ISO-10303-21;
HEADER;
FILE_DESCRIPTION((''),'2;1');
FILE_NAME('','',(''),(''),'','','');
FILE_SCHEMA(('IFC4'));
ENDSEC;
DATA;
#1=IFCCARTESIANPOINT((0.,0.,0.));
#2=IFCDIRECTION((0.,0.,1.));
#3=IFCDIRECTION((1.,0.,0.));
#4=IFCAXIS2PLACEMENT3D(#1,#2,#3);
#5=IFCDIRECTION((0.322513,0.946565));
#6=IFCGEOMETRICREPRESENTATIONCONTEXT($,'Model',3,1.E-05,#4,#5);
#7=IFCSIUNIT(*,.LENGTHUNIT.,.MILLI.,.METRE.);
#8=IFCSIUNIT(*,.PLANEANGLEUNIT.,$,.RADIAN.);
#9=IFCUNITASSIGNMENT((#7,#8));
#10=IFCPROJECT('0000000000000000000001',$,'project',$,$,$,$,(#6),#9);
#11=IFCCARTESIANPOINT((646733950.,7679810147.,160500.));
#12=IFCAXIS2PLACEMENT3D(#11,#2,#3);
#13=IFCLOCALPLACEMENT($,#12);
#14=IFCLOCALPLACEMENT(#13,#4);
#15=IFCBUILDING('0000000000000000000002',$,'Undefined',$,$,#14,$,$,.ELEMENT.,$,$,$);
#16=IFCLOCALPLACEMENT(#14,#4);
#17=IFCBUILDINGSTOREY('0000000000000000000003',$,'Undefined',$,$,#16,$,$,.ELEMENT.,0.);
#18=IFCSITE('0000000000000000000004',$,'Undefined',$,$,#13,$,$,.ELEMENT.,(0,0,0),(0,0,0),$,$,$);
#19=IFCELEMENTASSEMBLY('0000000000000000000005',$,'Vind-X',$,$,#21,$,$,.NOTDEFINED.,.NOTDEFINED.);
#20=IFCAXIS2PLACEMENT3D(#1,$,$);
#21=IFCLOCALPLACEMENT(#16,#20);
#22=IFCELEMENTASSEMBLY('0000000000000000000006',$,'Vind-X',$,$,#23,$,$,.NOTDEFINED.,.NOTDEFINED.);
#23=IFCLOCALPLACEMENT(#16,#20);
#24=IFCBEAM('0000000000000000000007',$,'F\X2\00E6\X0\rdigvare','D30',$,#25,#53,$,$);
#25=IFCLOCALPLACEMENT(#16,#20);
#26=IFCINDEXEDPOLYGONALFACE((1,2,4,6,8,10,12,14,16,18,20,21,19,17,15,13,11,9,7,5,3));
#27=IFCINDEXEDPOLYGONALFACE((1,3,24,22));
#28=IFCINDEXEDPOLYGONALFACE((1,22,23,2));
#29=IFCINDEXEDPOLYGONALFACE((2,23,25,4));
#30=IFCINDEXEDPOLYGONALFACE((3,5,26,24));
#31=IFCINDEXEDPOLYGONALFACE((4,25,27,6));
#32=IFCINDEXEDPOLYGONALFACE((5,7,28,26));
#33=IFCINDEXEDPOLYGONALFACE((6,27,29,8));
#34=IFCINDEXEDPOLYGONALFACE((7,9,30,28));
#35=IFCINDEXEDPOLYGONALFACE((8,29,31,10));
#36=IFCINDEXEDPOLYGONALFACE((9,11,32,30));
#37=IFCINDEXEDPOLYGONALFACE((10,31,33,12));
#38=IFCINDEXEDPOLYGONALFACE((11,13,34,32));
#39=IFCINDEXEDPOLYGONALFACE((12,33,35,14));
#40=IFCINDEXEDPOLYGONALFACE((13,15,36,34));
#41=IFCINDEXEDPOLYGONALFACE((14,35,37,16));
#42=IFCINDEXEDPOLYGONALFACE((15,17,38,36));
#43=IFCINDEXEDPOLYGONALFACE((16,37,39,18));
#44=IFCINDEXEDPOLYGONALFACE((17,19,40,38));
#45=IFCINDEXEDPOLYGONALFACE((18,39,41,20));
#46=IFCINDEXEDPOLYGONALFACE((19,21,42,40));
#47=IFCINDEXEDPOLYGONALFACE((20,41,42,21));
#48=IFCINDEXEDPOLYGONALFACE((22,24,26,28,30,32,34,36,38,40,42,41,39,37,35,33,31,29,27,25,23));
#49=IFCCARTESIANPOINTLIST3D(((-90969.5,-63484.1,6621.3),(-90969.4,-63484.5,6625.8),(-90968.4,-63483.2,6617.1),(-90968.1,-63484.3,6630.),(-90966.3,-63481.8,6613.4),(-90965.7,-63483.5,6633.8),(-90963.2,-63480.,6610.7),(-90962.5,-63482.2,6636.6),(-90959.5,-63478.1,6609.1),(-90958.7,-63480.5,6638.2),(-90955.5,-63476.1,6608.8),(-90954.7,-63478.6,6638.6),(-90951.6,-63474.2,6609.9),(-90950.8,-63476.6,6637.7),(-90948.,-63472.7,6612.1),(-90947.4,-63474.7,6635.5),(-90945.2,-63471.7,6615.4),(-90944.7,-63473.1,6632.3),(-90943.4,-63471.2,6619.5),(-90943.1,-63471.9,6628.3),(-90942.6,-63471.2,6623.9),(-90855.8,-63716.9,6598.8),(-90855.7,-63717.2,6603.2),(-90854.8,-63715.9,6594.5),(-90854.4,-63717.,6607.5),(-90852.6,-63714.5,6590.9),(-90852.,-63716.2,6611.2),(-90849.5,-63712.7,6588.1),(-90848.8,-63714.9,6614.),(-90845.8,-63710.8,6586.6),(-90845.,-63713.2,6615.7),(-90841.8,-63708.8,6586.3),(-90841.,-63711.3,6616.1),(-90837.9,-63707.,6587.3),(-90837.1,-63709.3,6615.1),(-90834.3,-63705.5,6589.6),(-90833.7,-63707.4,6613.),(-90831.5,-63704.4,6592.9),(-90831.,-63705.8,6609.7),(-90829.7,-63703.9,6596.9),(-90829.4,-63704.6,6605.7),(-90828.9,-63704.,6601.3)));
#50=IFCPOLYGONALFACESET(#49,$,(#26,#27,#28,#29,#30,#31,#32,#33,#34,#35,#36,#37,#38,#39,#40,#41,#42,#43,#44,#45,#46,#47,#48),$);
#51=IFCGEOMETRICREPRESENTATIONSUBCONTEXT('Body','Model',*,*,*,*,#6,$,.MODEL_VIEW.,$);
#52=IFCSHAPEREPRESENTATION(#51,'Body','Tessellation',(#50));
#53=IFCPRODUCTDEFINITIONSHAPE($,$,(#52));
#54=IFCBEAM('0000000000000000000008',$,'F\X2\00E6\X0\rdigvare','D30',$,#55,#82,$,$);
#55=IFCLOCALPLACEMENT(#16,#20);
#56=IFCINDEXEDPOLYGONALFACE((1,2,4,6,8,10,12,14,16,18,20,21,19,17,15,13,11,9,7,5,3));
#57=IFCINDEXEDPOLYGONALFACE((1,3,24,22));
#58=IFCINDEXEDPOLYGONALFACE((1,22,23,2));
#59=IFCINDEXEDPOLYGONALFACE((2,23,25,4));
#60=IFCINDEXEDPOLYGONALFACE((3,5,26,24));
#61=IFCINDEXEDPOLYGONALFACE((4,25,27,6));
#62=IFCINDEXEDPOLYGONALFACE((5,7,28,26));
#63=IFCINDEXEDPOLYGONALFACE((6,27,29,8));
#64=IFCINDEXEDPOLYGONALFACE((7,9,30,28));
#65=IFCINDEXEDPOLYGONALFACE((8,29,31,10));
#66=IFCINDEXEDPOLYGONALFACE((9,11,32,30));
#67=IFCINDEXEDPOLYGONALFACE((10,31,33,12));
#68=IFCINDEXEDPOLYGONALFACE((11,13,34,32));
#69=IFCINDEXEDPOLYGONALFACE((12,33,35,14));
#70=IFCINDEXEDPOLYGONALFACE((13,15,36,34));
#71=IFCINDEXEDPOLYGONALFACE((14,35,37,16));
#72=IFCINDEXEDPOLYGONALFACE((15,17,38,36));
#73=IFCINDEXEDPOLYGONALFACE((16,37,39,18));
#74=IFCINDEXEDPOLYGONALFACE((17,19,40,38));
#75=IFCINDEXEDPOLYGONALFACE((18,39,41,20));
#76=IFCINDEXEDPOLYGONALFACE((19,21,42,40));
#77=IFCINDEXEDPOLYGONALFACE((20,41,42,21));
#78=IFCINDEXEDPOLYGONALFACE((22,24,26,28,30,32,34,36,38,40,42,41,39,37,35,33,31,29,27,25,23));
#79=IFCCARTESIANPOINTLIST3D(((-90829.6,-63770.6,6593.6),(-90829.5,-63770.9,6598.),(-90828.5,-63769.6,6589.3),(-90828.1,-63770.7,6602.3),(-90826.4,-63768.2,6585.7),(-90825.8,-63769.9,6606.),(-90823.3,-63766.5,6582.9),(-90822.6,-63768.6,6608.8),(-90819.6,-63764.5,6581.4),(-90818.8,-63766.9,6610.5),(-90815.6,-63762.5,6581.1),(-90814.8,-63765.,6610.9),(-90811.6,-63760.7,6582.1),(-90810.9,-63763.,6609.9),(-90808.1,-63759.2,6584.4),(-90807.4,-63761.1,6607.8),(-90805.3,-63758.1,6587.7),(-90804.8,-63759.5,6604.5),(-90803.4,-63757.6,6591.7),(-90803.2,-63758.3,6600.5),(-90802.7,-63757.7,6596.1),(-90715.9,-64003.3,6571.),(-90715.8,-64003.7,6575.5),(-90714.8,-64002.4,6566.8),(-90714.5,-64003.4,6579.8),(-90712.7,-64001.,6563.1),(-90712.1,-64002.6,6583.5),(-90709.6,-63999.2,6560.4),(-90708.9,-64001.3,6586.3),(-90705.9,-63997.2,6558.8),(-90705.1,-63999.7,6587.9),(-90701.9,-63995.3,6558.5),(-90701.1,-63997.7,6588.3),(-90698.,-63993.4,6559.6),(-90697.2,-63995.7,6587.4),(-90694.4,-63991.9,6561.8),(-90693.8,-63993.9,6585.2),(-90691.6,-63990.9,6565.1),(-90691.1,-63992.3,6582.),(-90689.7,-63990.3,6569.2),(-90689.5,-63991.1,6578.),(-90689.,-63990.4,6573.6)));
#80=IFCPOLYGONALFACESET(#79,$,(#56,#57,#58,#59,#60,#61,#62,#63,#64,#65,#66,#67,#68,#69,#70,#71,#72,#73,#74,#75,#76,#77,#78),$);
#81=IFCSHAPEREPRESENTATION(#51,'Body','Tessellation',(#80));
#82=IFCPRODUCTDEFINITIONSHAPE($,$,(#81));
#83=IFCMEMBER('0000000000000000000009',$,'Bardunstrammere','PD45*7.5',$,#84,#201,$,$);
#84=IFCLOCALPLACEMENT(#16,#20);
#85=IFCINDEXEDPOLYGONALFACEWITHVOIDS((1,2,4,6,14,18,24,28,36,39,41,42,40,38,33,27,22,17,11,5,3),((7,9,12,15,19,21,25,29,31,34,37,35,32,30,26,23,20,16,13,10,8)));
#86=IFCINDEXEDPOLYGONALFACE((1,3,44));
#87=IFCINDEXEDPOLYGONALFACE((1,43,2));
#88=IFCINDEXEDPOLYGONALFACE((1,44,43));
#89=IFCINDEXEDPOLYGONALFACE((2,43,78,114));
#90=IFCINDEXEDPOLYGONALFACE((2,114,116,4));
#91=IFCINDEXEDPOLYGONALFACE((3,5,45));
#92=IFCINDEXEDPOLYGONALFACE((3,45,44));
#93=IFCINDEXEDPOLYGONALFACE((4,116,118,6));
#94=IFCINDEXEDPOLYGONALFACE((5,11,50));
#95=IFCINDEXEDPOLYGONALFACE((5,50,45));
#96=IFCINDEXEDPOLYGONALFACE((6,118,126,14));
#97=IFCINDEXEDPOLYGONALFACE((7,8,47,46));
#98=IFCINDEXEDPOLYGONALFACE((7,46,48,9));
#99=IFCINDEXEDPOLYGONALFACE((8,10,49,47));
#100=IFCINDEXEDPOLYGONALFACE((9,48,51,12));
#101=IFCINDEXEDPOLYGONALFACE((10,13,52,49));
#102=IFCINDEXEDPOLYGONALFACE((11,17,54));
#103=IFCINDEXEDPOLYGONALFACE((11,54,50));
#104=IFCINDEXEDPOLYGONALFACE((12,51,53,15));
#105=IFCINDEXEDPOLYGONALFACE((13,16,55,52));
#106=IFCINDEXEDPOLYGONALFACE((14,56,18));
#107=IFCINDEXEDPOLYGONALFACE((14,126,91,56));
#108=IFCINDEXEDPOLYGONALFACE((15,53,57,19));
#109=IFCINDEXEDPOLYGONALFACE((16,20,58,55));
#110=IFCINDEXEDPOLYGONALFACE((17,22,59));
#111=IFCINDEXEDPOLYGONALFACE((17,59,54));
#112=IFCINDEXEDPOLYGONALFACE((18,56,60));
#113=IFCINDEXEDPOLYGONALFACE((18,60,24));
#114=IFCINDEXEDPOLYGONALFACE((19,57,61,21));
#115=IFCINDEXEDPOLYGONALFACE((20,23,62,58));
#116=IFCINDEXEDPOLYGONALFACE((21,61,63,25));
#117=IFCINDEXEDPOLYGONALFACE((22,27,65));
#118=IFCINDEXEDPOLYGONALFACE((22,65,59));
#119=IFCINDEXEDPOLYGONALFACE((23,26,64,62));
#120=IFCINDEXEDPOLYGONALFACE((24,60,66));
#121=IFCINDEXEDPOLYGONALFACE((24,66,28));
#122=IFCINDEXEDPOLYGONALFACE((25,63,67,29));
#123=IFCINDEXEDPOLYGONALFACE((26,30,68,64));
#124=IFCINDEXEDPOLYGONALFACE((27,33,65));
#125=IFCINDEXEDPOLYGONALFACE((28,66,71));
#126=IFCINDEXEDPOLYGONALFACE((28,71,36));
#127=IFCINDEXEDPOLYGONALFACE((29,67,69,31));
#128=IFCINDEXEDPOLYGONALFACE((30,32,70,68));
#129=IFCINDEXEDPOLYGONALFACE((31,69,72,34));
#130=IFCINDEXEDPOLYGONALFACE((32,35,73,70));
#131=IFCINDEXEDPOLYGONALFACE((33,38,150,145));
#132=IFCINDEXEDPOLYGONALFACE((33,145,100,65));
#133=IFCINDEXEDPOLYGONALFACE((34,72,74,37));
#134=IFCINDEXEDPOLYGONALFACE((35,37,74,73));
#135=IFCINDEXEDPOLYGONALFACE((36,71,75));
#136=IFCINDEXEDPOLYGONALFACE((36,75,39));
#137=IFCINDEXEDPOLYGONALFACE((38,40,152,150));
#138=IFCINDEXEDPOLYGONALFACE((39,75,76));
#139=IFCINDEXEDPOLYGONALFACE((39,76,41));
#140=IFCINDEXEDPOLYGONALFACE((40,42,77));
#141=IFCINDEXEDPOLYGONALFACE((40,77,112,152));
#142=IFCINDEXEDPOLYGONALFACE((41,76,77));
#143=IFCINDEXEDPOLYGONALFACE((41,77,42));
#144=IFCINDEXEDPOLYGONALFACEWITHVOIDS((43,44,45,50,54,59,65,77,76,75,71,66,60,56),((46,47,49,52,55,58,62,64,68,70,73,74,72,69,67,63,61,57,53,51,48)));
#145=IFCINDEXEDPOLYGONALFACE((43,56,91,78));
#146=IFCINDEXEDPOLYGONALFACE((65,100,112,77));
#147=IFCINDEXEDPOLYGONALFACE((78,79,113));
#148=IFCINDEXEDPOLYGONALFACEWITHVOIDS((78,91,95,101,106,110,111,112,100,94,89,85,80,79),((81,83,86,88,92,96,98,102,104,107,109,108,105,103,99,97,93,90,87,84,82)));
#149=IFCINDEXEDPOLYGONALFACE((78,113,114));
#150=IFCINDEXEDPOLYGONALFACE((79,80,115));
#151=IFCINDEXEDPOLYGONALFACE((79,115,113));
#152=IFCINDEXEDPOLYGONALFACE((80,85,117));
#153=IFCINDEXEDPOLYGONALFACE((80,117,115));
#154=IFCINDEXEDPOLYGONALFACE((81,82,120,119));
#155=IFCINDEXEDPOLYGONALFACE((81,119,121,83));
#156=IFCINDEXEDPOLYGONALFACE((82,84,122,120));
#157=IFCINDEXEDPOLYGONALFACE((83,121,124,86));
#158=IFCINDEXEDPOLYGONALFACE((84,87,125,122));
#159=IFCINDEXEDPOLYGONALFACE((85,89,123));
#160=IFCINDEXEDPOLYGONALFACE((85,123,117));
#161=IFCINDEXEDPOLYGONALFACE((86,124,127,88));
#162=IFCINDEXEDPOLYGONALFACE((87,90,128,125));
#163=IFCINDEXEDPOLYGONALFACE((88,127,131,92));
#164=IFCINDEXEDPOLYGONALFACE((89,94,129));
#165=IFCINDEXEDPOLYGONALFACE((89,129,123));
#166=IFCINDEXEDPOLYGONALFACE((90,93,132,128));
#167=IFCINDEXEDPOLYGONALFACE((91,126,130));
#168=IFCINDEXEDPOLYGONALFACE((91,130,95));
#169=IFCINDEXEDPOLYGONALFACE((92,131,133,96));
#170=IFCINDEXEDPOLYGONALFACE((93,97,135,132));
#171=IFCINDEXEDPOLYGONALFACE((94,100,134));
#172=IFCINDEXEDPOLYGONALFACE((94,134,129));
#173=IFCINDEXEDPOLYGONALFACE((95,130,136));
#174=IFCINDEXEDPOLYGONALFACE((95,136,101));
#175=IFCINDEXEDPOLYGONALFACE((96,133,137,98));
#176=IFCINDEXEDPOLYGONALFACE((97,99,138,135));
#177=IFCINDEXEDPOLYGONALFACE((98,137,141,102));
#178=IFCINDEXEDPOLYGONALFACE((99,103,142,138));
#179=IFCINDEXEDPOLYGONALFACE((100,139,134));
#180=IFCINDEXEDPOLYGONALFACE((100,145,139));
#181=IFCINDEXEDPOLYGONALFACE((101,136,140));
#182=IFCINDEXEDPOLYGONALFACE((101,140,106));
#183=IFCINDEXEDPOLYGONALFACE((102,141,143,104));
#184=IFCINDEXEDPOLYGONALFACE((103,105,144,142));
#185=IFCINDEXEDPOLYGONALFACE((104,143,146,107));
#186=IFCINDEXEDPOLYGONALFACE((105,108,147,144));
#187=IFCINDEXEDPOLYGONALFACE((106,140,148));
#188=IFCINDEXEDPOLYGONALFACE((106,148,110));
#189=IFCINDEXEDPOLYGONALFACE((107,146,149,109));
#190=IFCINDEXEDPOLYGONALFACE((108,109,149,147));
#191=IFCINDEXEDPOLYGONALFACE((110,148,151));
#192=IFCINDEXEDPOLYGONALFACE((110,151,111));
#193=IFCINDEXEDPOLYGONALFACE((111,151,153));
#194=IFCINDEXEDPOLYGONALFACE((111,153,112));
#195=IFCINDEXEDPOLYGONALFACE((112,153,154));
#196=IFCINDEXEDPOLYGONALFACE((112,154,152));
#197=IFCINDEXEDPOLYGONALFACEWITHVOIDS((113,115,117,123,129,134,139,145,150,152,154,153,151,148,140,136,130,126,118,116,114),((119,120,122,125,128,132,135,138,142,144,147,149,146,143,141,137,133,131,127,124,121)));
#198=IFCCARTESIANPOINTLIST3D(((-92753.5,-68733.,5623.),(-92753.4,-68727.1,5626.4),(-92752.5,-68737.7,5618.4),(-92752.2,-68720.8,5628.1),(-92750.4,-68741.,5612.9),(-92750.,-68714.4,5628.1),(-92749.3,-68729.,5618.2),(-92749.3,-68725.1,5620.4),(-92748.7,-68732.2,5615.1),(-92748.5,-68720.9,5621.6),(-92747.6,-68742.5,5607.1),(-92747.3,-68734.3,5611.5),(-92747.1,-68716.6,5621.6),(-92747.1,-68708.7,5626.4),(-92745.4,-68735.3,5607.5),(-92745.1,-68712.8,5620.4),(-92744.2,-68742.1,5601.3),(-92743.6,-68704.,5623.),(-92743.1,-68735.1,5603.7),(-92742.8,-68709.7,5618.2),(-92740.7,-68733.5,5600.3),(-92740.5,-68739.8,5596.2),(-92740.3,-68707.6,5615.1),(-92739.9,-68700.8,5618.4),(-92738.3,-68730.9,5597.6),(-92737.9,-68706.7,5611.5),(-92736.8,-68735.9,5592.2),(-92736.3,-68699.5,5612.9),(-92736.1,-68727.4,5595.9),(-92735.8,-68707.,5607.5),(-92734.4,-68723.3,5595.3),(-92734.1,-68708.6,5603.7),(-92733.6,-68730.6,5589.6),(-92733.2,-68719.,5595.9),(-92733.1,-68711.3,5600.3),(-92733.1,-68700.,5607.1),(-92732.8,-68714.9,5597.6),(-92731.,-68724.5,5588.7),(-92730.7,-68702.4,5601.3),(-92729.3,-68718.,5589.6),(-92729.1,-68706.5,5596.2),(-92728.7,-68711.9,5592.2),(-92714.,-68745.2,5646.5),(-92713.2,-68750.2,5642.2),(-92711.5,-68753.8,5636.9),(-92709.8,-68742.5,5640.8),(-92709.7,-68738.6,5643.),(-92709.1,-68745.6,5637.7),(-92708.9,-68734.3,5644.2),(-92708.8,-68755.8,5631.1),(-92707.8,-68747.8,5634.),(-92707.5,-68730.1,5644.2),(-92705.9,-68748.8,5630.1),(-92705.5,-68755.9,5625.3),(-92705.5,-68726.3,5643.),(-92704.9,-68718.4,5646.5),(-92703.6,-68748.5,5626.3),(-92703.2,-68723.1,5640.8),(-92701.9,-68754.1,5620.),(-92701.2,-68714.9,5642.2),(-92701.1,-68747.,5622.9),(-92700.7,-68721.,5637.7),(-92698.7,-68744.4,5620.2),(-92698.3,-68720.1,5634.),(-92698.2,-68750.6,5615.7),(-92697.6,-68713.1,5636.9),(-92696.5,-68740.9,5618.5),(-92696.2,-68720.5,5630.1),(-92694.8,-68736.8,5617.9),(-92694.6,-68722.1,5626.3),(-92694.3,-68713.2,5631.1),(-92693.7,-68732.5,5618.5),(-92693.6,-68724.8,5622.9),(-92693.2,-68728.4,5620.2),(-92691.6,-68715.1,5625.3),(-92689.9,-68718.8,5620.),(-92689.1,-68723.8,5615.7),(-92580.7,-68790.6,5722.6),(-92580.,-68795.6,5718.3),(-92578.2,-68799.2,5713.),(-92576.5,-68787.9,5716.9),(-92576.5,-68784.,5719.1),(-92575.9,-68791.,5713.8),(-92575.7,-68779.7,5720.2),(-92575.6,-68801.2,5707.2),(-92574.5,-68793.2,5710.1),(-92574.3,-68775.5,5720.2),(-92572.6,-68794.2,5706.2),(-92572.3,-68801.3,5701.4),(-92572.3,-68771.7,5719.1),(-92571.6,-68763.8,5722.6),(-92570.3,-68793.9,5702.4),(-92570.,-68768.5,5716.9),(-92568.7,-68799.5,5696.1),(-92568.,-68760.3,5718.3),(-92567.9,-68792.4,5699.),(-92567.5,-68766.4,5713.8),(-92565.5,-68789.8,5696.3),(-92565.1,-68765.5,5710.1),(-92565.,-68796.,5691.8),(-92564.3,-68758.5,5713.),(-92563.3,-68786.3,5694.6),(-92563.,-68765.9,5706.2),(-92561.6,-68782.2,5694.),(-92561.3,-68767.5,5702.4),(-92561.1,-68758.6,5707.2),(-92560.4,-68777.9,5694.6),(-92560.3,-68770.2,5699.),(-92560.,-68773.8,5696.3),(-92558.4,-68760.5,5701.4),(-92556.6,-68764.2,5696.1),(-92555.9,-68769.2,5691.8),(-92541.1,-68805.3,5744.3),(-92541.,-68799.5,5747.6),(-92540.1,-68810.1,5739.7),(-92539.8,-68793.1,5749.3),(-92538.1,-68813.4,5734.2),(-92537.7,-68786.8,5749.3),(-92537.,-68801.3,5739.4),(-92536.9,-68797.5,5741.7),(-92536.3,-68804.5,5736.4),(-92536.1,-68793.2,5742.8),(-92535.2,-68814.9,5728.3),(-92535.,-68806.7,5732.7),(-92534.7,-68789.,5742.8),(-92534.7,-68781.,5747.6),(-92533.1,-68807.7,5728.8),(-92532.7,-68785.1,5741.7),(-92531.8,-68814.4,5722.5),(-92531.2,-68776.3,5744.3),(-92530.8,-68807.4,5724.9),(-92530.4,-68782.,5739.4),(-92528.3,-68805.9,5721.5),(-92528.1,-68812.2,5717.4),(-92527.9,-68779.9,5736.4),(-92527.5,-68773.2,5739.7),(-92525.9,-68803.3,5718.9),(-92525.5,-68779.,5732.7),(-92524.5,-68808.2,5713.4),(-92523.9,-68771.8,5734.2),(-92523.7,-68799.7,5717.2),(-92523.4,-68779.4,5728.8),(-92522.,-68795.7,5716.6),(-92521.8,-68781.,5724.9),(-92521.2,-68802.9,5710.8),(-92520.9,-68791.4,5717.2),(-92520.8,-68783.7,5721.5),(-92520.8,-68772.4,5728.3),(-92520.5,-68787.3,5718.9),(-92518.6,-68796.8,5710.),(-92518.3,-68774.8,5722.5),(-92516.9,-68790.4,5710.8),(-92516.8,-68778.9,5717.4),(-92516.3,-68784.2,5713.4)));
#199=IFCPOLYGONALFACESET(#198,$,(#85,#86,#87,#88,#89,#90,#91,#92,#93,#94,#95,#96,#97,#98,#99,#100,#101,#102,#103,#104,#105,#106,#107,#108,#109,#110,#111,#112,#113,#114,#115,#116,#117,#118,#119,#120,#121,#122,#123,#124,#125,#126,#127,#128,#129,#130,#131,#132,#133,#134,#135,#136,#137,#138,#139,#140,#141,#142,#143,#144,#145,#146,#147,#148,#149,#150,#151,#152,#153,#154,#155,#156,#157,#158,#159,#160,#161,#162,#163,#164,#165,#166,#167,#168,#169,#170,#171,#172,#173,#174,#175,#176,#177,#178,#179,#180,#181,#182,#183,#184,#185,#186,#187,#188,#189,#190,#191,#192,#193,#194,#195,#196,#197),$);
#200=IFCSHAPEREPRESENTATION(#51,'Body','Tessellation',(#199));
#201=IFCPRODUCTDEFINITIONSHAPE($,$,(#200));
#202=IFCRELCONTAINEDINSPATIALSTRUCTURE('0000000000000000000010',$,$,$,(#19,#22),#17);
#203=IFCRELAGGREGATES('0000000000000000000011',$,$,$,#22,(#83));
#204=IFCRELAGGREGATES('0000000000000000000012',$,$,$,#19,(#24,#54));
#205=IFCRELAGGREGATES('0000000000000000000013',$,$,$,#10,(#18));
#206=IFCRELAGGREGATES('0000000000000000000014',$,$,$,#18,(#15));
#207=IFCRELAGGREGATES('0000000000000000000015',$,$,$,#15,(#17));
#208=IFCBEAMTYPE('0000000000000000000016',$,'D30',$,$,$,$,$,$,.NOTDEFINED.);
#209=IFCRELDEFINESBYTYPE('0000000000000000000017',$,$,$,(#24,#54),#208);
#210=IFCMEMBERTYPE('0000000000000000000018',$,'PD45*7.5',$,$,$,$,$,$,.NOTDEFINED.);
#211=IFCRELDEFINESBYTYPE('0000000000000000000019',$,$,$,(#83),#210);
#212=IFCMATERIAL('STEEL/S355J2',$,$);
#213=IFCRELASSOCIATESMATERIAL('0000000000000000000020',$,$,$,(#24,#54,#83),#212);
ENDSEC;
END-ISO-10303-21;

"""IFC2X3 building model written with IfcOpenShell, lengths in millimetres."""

from ifc_helpers import new_model, si_unit, direction, frame, origin_with_axes, origin_2d_with_axis, place, context, subcontext, project, spatial, rectangle, circle, hollow_circle, extrude, boolean, material, type_object, element, aggregate, save


model = new_model("IFC2X3")

# Units and contexts
model_context = context("Model", 3, precision=1e-05, world=origin_with_axes(), true_north=direction((0.322513, 0.946565)))
body_context = subcontext(model_context, "Body", "Model", "MODEL_VIEW")
ifc_project = project(units=[si_unit("LENGTHUNIT", "METRE", prefix="MILLI"), si_unit("PLANEANGLEUNIT", "RADIAN")], contexts=[model_context])

# Site, building, storey
site_placement = place(None, frame((646733950.0, 7679810147.0, 160500.0), z_axis=(0.0, 0.0, 1.0), x_axis=(1.0, 0.0, 0.0)))
site = spatial("IfcSite", under=ifc_project, at=site_placement, Name="Undefined", CompositionType="ELEMENT", RefLatitude=(0, 0, 0), RefLongitude=(0, 0, 0))
building_placement = place(site_placement, origin_with_axes())
building = spatial("IfcBuilding", under=site, at=building_placement, Name="Undefined", CompositionType="ELEMENT")
storey_placement = place(building_placement, origin_with_axes())
storey = spatial("IfcBuildingStorey", under=building, at=storey_placement, Name="Undefined", CompositionType="ELEMENT", Elevation=0.0)

# Element assembly
assembly_1_placement = place(storey_placement, origin_with_axes())
assembly_1 = element("IfcElementAssembly", 1, at=assembly_1_placement, inside=storey, Name="Vind-X", AssemblyPlace="NOTDEFINED", PredefinedType="NOTDEFINED")
ifc_material_1 = material(Name="STEEL/S355J2")

# Element assembly
assembly_2_placement = place(storey_placement, origin_with_axes())
assembly_2 = element("IfcElementAssembly", 2, at=assembly_2_placement, inside=storey, Name="Vind-X", AssemblyPlace="NOTDEFINED", PredefinedType="NOTDEFINED")

# Beams
beam_type_1 = type_object("IfcBeamType", Name="D30", PredefinedType="NOTDEFINED")
beam_1_placement = place(assembly_1_placement, frame((-90842.4, -63710.5, 6601.2), z_axis=(0.898475, 0.430594, 0.085624), x_axis=(-0.437262, 0.895143, 0.086721)))
beam_1 = element("IfcBeam", 3, at=beam_1_placement, type_object=beam_type_1, material=ifc_material_1, Name="Færdigvare", Description="D30", context=body_context, shape_type="SweptSolid", body=[
    extrude(circle(Radius=15.0, at=origin_2d_with_axis()), frame((260.0, 0.0, 0.0), z_axis=(-1.0, 0.0, 0.0), x_axis=(0.0, -1.0, 0.0)), (0.0, 0.0, 1.0), 260.0),
])
beam_2_placement = place(assembly_1_placement, frame((-90702.5, -63997.0, 6573.4), z_axis=(0.898474, 0.430595, 0.085625), x_axis=(-0.437263, 0.895143, 0.086721)))
beam_2 = element("IfcBeam", 4, at=beam_2_placement, type_object=beam_type_1, material=ifc_material_1, Name="Færdigvare", Description="D30", context=body_context, shape_type="SweptSolid", body=[
    extrude(circle(Radius=15.0, at=origin_2d_with_axis()), frame((260.0, 0.0, 0.0), z_axis=(-1.0, 0.0, 0.0), x_axis=(0.0, -1.0, 0.0)), (0.0, 0.0, 1.0), 260.0),
])

# Member
member_type_1 = type_object("IfcMemberType", Name="PD45*7.5", PredefinedType="NOTDEFINED")
member_1_placement = place(assembly_2_placement, frame((-92528.8, -68793.4, 5729.8), z_axis=(0.322513, 0.946565, 0.0), x_axis=(-0.832751, 0.283734, -0.475416)))
member_1 = element("IfcMember", 5, at=member_1_placement, type_object=member_type_1, material=ifc_material_1, Name="Bardunstrammere", Description="PD45*7.5", context=body_context, shape_type="CSG", body=[
    boolean("DIFFERENCE", extrude(hollow_circle(Radius=22.5, WallThickness=7.5, at=origin_2d_with_axis()), frame((255.0, 0.0, 0.0), z_axis=(-1.0, 0.0, 0.0), x_axis=(0.0, -1.0, 0.0)), (0.0, 0.0, 1.0), 255.0), extrude(rectangle(XDim=35.0, YDim=90.0, at=origin_2d_with_axis()), frame((207.5, 0.0, 0.0), z_axis=(-1.0, 0.0, 0.0), x_axis=(0.0, -1.0, 0.0)), (0.0, 0.0, 1.0), 160.0)),
])
aggregate(assembly_2, [member_1])

aggregate(assembly_1, [beam_1, beam_2])

save(model, "model.ifc")
